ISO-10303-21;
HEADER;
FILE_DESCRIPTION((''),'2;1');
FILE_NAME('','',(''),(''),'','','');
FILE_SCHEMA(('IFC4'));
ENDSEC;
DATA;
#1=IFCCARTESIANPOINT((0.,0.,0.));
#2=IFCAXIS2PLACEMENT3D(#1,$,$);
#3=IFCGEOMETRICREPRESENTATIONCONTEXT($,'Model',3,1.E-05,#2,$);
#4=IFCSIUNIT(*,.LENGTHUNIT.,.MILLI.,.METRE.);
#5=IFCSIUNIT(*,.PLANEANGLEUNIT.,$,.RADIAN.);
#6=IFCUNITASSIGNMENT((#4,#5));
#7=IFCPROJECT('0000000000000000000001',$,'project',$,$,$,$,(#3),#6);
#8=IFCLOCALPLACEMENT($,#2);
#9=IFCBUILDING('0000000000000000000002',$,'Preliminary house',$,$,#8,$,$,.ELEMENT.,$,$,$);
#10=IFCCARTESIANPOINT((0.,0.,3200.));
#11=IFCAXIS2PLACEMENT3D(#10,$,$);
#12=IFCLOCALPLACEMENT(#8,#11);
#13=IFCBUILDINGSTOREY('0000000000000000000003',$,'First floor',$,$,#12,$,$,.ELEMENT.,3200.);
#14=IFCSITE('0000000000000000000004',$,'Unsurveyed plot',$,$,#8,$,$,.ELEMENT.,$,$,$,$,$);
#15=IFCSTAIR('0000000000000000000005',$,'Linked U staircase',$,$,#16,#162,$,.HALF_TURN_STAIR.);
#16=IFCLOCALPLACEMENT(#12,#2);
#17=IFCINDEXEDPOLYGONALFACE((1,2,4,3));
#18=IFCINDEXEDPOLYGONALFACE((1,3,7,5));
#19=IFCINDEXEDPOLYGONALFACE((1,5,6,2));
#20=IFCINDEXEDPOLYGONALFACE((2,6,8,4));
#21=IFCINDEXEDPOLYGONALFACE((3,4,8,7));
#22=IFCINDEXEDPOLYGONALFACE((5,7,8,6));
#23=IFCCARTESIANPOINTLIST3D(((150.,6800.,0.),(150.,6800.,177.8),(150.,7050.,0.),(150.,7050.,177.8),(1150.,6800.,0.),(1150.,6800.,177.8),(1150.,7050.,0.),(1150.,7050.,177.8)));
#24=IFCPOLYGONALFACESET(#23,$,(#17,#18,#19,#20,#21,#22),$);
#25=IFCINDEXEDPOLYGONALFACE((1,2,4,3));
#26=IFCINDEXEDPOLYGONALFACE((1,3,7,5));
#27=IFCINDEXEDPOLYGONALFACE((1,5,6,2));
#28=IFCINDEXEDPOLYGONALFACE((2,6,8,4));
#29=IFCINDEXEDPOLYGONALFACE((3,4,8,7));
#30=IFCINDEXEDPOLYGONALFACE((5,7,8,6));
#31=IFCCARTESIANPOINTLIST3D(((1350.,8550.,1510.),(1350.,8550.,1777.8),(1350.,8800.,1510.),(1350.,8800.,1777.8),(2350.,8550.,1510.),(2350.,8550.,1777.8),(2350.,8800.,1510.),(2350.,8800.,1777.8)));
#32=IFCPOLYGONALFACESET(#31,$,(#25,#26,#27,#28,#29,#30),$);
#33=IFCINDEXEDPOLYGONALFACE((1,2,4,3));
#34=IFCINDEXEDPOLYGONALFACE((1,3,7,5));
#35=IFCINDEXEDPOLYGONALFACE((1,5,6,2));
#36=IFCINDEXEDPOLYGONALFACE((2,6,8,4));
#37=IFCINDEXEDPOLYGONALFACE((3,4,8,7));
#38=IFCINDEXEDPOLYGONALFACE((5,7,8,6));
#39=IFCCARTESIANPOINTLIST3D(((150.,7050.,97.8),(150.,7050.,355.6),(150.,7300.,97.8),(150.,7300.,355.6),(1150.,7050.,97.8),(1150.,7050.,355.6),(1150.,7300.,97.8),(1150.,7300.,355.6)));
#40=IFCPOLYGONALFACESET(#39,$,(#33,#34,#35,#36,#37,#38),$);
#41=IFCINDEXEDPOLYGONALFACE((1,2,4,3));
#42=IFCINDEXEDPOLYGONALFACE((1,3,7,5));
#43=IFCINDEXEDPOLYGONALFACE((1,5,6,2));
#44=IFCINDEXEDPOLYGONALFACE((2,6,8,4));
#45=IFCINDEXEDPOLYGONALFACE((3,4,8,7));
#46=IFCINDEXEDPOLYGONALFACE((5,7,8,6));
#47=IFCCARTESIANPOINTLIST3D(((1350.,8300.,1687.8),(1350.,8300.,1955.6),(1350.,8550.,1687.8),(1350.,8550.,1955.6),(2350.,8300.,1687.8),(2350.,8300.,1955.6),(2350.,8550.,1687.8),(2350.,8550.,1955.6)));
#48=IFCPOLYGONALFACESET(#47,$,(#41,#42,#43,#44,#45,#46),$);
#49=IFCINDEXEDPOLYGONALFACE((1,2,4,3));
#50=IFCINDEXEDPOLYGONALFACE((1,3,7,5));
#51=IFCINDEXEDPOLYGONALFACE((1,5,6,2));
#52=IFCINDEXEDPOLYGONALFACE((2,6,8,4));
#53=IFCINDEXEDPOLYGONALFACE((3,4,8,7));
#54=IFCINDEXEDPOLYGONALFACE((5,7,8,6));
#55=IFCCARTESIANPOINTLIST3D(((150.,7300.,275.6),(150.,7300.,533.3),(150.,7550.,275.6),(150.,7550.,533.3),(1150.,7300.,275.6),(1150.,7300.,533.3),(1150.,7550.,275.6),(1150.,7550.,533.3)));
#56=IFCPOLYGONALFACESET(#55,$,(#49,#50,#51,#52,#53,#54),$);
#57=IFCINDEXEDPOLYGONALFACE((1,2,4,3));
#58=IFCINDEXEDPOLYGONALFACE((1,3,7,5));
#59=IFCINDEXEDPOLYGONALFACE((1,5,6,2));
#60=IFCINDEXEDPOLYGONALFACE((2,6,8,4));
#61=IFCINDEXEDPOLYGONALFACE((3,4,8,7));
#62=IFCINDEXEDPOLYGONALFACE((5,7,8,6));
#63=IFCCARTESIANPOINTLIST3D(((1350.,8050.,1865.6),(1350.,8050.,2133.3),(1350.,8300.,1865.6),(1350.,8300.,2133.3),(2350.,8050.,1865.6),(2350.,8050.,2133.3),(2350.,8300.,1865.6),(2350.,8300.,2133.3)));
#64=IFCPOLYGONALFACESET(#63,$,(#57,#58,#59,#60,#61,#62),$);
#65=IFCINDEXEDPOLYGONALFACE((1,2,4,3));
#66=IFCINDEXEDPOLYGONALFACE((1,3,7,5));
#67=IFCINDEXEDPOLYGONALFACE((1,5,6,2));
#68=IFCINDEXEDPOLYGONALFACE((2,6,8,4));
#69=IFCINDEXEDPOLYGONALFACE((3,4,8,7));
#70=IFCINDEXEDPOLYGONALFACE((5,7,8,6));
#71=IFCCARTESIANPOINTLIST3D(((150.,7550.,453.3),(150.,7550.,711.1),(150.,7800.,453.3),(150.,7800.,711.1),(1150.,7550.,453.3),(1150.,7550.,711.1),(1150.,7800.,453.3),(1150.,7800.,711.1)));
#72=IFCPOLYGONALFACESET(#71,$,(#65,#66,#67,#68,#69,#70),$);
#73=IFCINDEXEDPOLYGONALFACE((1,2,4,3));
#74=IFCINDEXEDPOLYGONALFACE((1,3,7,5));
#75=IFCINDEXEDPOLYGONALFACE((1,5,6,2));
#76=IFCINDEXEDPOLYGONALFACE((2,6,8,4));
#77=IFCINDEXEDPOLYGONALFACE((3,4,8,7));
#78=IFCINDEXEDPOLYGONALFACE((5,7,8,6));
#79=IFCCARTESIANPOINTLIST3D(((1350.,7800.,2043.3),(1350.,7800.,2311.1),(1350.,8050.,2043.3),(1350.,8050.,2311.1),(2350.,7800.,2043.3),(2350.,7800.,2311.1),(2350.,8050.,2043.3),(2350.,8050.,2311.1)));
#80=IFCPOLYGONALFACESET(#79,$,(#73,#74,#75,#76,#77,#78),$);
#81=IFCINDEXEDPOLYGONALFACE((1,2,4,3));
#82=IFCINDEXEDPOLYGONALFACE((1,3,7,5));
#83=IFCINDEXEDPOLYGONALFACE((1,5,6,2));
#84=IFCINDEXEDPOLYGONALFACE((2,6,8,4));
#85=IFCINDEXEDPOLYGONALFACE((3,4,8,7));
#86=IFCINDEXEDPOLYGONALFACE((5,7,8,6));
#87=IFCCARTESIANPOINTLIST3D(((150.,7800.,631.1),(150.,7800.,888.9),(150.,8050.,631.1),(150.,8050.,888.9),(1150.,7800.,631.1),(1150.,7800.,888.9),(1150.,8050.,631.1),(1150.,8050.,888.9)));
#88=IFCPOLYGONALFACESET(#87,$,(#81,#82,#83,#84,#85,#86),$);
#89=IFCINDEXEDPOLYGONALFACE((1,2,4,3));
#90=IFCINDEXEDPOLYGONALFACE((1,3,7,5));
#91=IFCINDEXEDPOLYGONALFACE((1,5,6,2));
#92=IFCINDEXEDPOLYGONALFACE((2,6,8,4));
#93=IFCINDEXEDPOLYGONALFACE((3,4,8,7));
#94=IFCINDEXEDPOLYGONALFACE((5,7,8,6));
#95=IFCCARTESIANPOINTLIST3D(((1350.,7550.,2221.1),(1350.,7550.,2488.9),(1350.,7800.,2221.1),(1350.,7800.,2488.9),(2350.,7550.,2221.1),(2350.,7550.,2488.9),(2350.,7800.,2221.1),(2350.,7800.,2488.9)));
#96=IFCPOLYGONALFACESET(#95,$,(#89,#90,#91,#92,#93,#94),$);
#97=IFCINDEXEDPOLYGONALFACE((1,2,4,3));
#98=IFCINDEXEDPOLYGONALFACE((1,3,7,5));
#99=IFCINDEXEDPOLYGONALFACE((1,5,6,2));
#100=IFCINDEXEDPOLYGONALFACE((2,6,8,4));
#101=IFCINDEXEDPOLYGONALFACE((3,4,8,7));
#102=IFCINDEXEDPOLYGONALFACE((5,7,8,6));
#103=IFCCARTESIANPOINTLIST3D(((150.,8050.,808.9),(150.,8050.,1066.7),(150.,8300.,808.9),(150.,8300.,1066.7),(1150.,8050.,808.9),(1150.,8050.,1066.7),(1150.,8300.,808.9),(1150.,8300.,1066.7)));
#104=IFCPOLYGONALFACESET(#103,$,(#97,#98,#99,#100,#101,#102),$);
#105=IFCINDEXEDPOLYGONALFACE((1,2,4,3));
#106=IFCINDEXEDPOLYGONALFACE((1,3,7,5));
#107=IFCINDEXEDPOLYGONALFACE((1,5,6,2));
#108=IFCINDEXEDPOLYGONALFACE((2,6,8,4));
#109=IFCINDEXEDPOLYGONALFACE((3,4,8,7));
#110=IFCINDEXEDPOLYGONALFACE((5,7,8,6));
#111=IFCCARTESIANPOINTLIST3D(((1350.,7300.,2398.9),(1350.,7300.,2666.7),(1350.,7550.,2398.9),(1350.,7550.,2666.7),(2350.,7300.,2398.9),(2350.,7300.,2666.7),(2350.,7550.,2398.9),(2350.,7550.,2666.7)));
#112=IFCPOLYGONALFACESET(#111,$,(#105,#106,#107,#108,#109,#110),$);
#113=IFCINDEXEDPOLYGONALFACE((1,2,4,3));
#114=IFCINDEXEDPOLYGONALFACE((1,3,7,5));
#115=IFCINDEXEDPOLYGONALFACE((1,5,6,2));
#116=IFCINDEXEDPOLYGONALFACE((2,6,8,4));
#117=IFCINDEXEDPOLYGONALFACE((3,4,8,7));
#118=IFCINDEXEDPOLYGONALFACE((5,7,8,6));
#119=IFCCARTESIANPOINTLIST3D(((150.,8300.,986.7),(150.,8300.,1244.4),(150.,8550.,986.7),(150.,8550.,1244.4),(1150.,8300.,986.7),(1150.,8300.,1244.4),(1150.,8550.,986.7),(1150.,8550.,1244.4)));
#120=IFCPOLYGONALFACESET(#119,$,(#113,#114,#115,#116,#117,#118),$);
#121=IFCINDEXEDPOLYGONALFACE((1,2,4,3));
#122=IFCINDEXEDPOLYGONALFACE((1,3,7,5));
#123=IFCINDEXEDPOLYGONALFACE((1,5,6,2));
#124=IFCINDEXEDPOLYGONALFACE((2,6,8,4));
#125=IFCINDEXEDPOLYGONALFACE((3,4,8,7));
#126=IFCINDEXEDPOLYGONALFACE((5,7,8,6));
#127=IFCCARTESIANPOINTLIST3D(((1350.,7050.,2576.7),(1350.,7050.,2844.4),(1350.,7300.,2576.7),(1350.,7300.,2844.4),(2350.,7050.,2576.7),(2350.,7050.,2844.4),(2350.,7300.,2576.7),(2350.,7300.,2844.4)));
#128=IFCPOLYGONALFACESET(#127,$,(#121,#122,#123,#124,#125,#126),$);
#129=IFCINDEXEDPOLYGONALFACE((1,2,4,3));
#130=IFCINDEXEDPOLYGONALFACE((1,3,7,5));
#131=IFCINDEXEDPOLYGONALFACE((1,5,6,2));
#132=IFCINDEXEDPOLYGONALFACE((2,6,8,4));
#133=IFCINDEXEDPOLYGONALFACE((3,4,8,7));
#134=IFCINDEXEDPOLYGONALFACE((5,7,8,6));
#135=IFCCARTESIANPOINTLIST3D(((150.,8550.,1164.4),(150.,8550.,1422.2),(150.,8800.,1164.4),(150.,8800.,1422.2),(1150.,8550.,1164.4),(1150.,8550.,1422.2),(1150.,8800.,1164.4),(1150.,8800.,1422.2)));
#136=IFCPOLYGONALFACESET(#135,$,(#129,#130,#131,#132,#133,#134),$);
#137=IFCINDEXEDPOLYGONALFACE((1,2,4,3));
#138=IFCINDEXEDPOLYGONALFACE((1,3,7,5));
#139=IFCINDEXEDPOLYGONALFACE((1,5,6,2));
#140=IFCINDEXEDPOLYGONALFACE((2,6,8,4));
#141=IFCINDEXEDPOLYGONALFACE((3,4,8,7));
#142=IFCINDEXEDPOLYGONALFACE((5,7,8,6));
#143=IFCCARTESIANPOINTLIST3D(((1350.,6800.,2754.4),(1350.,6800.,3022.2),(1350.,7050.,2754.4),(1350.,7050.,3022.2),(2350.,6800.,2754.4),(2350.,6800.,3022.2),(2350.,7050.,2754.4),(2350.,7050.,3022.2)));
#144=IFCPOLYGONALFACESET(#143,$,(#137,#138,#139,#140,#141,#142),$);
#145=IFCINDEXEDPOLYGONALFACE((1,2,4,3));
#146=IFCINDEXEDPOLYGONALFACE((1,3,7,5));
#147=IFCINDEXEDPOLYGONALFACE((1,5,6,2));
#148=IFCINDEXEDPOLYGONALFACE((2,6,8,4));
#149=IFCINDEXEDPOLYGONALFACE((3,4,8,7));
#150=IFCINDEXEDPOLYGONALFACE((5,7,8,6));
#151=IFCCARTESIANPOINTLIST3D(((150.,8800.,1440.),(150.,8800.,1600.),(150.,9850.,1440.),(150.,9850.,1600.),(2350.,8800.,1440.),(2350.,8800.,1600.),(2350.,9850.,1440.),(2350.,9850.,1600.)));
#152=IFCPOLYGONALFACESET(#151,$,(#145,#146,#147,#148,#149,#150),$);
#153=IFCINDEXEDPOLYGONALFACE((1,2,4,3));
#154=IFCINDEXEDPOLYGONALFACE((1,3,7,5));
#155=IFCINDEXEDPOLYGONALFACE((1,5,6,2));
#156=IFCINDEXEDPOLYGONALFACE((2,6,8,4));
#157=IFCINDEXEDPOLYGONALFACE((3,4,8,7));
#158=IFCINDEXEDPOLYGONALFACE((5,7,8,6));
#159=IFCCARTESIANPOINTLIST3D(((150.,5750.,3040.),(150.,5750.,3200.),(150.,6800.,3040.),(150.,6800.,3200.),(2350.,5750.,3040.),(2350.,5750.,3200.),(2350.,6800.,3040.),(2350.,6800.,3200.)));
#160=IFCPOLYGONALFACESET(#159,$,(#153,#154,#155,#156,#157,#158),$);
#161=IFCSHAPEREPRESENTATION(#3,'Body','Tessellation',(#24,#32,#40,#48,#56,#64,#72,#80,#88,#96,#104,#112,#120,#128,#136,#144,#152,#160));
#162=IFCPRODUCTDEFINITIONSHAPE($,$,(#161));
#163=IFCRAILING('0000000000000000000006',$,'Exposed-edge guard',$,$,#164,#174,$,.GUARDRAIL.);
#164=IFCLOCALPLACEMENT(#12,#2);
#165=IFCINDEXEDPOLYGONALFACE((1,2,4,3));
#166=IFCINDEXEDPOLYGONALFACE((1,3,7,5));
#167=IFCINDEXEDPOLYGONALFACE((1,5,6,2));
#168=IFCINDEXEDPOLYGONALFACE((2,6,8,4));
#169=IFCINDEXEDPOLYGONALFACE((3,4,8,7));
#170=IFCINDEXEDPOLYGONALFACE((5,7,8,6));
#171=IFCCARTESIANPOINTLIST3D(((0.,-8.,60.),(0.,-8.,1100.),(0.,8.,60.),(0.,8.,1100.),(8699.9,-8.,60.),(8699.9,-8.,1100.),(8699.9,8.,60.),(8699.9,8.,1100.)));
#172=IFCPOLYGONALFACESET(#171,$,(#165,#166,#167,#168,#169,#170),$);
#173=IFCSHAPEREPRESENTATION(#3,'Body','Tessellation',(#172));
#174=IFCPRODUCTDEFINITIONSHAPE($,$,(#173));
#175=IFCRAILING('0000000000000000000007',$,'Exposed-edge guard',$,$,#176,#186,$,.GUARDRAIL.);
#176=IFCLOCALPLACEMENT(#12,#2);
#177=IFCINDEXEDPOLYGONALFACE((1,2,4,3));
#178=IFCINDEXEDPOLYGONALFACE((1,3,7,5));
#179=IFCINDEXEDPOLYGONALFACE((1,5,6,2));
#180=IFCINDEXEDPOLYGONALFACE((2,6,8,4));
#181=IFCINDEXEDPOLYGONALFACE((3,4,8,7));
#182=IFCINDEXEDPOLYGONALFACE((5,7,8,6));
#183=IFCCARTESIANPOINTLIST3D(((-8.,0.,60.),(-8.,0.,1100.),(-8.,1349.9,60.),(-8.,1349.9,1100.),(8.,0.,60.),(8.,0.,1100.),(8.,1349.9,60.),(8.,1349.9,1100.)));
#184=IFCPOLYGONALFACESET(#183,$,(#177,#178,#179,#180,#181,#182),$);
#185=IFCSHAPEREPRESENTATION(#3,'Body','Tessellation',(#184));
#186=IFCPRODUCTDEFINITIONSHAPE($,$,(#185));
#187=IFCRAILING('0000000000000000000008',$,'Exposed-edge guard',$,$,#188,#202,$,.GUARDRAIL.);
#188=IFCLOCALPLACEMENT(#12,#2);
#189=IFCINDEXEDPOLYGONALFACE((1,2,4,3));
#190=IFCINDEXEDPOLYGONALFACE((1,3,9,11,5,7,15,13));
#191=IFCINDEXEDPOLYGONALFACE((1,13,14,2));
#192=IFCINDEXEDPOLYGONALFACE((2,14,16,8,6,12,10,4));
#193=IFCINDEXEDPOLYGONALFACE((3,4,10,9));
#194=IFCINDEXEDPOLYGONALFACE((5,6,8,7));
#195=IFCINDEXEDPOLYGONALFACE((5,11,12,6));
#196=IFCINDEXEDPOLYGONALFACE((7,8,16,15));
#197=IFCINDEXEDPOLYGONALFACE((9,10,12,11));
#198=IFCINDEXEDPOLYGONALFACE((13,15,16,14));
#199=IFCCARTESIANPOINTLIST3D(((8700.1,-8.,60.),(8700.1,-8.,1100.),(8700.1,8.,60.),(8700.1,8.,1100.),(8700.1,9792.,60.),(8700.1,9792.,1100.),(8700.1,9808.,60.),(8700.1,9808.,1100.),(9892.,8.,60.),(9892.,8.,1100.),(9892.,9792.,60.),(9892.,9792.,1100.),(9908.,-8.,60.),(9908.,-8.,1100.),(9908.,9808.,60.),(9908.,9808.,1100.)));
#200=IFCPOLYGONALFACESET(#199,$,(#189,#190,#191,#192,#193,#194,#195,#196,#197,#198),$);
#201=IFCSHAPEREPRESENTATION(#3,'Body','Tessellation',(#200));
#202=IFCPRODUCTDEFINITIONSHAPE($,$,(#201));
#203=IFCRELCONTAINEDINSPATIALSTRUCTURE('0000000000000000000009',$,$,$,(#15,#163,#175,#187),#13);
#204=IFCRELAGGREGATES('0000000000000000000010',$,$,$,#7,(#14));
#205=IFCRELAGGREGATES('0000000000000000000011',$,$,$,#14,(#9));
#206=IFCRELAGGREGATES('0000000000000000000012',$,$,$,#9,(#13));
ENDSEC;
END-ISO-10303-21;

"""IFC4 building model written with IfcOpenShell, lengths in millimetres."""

from ifc_helpers import new_model, si_unit, frame, origin, place, context, project, spatial, polyline, outline, extrude, element, save


model = new_model("IFC4")

# Units and contexts
model_context = context("Model", 3, precision=1e-05, world=origin())
ifc_project = project(units=[si_unit("LENGTHUNIT", "METRE", prefix="MILLI"), si_unit("PLANEANGLEUNIT", "RADIAN")], contexts=[model_context])

# Site, building, storey
placement_1 = place(None, origin())
site = spatial("IfcSite", under=ifc_project, at=placement_1, Name="Unsurveyed plot", CompositionType="ELEMENT")
building = spatial("IfcBuilding", under=site, at=placement_1, Name="Preliminary house", CompositionType="ELEMENT")
placement_2 = place(placement_1, frame((0.0, 0.0, 3200.0)))
storey = spatial("IfcBuildingStorey", under=building, at=placement_2, Name="First floor", CompositionType="ELEMENT", Elevation=3200.0)

# Stair
element("IfcStair", 1, at=placement_2, inside=storey, Name="Linked U staircase", PredefinedType="HALF_TURN_STAIR", context=model_context, shape_type="SweptSolid", body=[
    extrude(outline(polyline([(1150.0, 6800.0), (1150.0, 7050.0), (150.0, 7050.0), (150.0, 6800.0), (1150.0, 6800.0)])), origin(), (0.0, 0.0, 1.0), 177.8),
    extrude(outline(polyline([(2350.0, 8550.0), (2350.0, 8800.0), (1350.0, 8800.0), (1350.0, 8550.0), (2350.0, 8550.0)])), frame((0.0, 0.0, 1510.0)), (0.0, 0.0, 1.0), 267.8),
    extrude(outline(polyline([(1150.0, 7050.0), (1150.0, 7300.0), (150.0, 7300.0), (150.0, 7050.0), (1150.0, 7050.0)])), frame((0.0, 0.0, 97.8)), (0.0, 0.0, 1.0), 257.8),
    extrude(outline(polyline([(2350.0, 8300.0), (2350.0, 8550.0), (1350.0, 8550.0), (1350.0, 8300.0), (2350.0, 8300.0)])), frame((0.0, 0.0, 1687.8)), (0.0, 0.0, 1.0), 267.8),
    extrude(outline(polyline([(1150.0, 7300.0), (1150.0, 7550.0), (150.0, 7550.0), (150.0, 7300.0), (1150.0, 7300.0)])), frame((0.0, 0.0, 275.6)), (0.0, 0.0, 1.0), 257.8),
    extrude(outline(polyline([(2350.0, 8050.0), (2350.0, 8300.0), (1350.0, 8300.0), (1350.0, 8050.0), (2350.0, 8050.0)])), frame((0.0, 0.0, 1865.6)), (0.0, 0.0, 1.0), 267.8),
    extrude(outline(polyline([(1150.0, 7550.0), (1150.0, 7800.0), (150.0, 7800.0), (150.0, 7550.0), (1150.0, 7550.0)])), frame((0.0, 0.0, 453.3)), (0.0, 0.0, 1.0), 257.8),
    extrude(outline(polyline([(2350.0, 7800.0), (2350.0, 8050.0), (1350.0, 8050.0), (1350.0, 7800.0), (2350.0, 7800.0)])), frame((0.0, 0.0, 2043.3)), (0.0, 0.0, 1.0), 267.8),
    extrude(outline(polyline([(1150.0, 7800.0), (1150.0, 8050.0), (150.0, 8050.0), (150.0, 7800.0), (1150.0, 7800.0)])), frame((0.0, 0.0, 631.1)), (0.0, 0.0, 1.0), 257.8),
    extrude(outline(polyline([(2350.0, 7550.0), (2350.0, 7800.0), (1350.0, 7800.0), (1350.0, 7550.0), (2350.0, 7550.0)])), frame((0.0, 0.0, 2221.1)), (0.0, 0.0, 1.0), 267.8),
    extrude(outline(polyline([(1150.0, 8050.0), (1150.0, 8300.0), (150.0, 8300.0), (150.0, 8050.0), (1150.0, 8050.0)])), frame((0.0, 0.0, 808.9)), (0.0, 0.0, 1.0), 257.8),
    extrude(outline(polyline([(2350.0, 7300.0), (2350.0, 7550.0), (1350.0, 7550.0), (1350.0, 7300.0), (2350.0, 7300.0)])), frame((0.0, 0.0, 2398.9)), (0.0, 0.0, 1.0), 267.8),
    extrude(outline(polyline([(1150.0, 8300.0), (1150.0, 8550.0), (150.0, 8550.0), (150.0, 8300.0), (1150.0, 8300.0)])), frame((0.0, 0.0, 986.7)), (0.0, 0.0, 1.0), 257.8),
    extrude(outline(polyline([(2350.0, 7050.0), (2350.0, 7300.0), (1350.0, 7300.0), (1350.0, 7050.0), (2350.0, 7050.0)])), frame((0.0, 0.0, 2576.7)), (0.0, 0.0, 1.0), 267.8),
    extrude(outline(polyline([(1150.0, 8550.0), (1150.0, 8800.0), (150.0, 8800.0), (150.0, 8550.0), (1150.0, 8550.0)])), frame((0.0, 0.0, 1164.4)), (0.0, 0.0, 1.0), 257.8),
    extrude(outline(polyline([(2350.0, 6800.0), (2350.0, 7050.0), (1350.0, 7050.0), (1350.0, 6800.0), (2350.0, 6800.0)])), frame((0.0, 0.0, 2754.4)), (0.0, 0.0, 1.0), 267.8),
    extrude(outline(polyline([(2350.0, 8800.0), (2350.0, 9850.0), (150.0, 9850.0), (150.0, 8800.0), (2350.0, 8800.0)])), frame((0.0, 0.0, 1440.0)), (0.0, 0.0, 1.0), 160.0),
    extrude(outline(polyline([(2350.0, 5750.0), (2350.0, 6800.0), (150.0, 6800.0), (150.0, 5750.0), (2350.0, 5750.0)])), frame((0.0, 0.0, 3040.0)), (0.0, 0.0, 1.0), 160.0),
])

# Railings
element("IfcRailing", 2, at=placement_2, inside=storey, Name="Exposed-edge guard", PredefinedType="GUARDRAIL", context=model_context, shape_type="SweptSolid", body=[
    extrude(outline(polyline([(8699.9, 8.0), (8699.9, -8.0), (0.0, -8.0), (0.0, 8.0), (8699.9, 8.0)])), frame((0.0, 0.0, 60.0)), (0.0, 0.0, 1.0), 1040.0),
])
element("IfcRailing", 3, at=placement_2, inside=storey, Name="Exposed-edge guard", PredefinedType="GUARDRAIL", context=model_context, shape_type="SweptSolid", body=[
    extrude(outline(polyline([(8.0, 0.0), (-8.0, 0.0), (-8.0, 1349.9), (8.0, 1349.9), (8.0, 0.0)])), frame((0.0, 0.0, 60.0)), (0.0, 0.0, 1.0), 1040.0),
])
element("IfcRailing", 4, at=placement_2, inside=storey, Name="Exposed-edge guard", PredefinedType="GUARDRAIL", context=model_context, shape_type="SweptSolid", body=[
    extrude(outline(polyline([(9892.0, 8.0), (9892.0, 9792.0), (8700.1, 9792.0), (8700.1, 9808.0), (9908.0, 9808.0), (9908.0, -8.0), (8700.1, -8.0), (8700.1, 8.0), (9892.0, 8.0)])), frame((0.0, 0.0, 60.0)), (0.0, 0.0, 1.0), 1040.0),
])

save(model, "model.ifc")
